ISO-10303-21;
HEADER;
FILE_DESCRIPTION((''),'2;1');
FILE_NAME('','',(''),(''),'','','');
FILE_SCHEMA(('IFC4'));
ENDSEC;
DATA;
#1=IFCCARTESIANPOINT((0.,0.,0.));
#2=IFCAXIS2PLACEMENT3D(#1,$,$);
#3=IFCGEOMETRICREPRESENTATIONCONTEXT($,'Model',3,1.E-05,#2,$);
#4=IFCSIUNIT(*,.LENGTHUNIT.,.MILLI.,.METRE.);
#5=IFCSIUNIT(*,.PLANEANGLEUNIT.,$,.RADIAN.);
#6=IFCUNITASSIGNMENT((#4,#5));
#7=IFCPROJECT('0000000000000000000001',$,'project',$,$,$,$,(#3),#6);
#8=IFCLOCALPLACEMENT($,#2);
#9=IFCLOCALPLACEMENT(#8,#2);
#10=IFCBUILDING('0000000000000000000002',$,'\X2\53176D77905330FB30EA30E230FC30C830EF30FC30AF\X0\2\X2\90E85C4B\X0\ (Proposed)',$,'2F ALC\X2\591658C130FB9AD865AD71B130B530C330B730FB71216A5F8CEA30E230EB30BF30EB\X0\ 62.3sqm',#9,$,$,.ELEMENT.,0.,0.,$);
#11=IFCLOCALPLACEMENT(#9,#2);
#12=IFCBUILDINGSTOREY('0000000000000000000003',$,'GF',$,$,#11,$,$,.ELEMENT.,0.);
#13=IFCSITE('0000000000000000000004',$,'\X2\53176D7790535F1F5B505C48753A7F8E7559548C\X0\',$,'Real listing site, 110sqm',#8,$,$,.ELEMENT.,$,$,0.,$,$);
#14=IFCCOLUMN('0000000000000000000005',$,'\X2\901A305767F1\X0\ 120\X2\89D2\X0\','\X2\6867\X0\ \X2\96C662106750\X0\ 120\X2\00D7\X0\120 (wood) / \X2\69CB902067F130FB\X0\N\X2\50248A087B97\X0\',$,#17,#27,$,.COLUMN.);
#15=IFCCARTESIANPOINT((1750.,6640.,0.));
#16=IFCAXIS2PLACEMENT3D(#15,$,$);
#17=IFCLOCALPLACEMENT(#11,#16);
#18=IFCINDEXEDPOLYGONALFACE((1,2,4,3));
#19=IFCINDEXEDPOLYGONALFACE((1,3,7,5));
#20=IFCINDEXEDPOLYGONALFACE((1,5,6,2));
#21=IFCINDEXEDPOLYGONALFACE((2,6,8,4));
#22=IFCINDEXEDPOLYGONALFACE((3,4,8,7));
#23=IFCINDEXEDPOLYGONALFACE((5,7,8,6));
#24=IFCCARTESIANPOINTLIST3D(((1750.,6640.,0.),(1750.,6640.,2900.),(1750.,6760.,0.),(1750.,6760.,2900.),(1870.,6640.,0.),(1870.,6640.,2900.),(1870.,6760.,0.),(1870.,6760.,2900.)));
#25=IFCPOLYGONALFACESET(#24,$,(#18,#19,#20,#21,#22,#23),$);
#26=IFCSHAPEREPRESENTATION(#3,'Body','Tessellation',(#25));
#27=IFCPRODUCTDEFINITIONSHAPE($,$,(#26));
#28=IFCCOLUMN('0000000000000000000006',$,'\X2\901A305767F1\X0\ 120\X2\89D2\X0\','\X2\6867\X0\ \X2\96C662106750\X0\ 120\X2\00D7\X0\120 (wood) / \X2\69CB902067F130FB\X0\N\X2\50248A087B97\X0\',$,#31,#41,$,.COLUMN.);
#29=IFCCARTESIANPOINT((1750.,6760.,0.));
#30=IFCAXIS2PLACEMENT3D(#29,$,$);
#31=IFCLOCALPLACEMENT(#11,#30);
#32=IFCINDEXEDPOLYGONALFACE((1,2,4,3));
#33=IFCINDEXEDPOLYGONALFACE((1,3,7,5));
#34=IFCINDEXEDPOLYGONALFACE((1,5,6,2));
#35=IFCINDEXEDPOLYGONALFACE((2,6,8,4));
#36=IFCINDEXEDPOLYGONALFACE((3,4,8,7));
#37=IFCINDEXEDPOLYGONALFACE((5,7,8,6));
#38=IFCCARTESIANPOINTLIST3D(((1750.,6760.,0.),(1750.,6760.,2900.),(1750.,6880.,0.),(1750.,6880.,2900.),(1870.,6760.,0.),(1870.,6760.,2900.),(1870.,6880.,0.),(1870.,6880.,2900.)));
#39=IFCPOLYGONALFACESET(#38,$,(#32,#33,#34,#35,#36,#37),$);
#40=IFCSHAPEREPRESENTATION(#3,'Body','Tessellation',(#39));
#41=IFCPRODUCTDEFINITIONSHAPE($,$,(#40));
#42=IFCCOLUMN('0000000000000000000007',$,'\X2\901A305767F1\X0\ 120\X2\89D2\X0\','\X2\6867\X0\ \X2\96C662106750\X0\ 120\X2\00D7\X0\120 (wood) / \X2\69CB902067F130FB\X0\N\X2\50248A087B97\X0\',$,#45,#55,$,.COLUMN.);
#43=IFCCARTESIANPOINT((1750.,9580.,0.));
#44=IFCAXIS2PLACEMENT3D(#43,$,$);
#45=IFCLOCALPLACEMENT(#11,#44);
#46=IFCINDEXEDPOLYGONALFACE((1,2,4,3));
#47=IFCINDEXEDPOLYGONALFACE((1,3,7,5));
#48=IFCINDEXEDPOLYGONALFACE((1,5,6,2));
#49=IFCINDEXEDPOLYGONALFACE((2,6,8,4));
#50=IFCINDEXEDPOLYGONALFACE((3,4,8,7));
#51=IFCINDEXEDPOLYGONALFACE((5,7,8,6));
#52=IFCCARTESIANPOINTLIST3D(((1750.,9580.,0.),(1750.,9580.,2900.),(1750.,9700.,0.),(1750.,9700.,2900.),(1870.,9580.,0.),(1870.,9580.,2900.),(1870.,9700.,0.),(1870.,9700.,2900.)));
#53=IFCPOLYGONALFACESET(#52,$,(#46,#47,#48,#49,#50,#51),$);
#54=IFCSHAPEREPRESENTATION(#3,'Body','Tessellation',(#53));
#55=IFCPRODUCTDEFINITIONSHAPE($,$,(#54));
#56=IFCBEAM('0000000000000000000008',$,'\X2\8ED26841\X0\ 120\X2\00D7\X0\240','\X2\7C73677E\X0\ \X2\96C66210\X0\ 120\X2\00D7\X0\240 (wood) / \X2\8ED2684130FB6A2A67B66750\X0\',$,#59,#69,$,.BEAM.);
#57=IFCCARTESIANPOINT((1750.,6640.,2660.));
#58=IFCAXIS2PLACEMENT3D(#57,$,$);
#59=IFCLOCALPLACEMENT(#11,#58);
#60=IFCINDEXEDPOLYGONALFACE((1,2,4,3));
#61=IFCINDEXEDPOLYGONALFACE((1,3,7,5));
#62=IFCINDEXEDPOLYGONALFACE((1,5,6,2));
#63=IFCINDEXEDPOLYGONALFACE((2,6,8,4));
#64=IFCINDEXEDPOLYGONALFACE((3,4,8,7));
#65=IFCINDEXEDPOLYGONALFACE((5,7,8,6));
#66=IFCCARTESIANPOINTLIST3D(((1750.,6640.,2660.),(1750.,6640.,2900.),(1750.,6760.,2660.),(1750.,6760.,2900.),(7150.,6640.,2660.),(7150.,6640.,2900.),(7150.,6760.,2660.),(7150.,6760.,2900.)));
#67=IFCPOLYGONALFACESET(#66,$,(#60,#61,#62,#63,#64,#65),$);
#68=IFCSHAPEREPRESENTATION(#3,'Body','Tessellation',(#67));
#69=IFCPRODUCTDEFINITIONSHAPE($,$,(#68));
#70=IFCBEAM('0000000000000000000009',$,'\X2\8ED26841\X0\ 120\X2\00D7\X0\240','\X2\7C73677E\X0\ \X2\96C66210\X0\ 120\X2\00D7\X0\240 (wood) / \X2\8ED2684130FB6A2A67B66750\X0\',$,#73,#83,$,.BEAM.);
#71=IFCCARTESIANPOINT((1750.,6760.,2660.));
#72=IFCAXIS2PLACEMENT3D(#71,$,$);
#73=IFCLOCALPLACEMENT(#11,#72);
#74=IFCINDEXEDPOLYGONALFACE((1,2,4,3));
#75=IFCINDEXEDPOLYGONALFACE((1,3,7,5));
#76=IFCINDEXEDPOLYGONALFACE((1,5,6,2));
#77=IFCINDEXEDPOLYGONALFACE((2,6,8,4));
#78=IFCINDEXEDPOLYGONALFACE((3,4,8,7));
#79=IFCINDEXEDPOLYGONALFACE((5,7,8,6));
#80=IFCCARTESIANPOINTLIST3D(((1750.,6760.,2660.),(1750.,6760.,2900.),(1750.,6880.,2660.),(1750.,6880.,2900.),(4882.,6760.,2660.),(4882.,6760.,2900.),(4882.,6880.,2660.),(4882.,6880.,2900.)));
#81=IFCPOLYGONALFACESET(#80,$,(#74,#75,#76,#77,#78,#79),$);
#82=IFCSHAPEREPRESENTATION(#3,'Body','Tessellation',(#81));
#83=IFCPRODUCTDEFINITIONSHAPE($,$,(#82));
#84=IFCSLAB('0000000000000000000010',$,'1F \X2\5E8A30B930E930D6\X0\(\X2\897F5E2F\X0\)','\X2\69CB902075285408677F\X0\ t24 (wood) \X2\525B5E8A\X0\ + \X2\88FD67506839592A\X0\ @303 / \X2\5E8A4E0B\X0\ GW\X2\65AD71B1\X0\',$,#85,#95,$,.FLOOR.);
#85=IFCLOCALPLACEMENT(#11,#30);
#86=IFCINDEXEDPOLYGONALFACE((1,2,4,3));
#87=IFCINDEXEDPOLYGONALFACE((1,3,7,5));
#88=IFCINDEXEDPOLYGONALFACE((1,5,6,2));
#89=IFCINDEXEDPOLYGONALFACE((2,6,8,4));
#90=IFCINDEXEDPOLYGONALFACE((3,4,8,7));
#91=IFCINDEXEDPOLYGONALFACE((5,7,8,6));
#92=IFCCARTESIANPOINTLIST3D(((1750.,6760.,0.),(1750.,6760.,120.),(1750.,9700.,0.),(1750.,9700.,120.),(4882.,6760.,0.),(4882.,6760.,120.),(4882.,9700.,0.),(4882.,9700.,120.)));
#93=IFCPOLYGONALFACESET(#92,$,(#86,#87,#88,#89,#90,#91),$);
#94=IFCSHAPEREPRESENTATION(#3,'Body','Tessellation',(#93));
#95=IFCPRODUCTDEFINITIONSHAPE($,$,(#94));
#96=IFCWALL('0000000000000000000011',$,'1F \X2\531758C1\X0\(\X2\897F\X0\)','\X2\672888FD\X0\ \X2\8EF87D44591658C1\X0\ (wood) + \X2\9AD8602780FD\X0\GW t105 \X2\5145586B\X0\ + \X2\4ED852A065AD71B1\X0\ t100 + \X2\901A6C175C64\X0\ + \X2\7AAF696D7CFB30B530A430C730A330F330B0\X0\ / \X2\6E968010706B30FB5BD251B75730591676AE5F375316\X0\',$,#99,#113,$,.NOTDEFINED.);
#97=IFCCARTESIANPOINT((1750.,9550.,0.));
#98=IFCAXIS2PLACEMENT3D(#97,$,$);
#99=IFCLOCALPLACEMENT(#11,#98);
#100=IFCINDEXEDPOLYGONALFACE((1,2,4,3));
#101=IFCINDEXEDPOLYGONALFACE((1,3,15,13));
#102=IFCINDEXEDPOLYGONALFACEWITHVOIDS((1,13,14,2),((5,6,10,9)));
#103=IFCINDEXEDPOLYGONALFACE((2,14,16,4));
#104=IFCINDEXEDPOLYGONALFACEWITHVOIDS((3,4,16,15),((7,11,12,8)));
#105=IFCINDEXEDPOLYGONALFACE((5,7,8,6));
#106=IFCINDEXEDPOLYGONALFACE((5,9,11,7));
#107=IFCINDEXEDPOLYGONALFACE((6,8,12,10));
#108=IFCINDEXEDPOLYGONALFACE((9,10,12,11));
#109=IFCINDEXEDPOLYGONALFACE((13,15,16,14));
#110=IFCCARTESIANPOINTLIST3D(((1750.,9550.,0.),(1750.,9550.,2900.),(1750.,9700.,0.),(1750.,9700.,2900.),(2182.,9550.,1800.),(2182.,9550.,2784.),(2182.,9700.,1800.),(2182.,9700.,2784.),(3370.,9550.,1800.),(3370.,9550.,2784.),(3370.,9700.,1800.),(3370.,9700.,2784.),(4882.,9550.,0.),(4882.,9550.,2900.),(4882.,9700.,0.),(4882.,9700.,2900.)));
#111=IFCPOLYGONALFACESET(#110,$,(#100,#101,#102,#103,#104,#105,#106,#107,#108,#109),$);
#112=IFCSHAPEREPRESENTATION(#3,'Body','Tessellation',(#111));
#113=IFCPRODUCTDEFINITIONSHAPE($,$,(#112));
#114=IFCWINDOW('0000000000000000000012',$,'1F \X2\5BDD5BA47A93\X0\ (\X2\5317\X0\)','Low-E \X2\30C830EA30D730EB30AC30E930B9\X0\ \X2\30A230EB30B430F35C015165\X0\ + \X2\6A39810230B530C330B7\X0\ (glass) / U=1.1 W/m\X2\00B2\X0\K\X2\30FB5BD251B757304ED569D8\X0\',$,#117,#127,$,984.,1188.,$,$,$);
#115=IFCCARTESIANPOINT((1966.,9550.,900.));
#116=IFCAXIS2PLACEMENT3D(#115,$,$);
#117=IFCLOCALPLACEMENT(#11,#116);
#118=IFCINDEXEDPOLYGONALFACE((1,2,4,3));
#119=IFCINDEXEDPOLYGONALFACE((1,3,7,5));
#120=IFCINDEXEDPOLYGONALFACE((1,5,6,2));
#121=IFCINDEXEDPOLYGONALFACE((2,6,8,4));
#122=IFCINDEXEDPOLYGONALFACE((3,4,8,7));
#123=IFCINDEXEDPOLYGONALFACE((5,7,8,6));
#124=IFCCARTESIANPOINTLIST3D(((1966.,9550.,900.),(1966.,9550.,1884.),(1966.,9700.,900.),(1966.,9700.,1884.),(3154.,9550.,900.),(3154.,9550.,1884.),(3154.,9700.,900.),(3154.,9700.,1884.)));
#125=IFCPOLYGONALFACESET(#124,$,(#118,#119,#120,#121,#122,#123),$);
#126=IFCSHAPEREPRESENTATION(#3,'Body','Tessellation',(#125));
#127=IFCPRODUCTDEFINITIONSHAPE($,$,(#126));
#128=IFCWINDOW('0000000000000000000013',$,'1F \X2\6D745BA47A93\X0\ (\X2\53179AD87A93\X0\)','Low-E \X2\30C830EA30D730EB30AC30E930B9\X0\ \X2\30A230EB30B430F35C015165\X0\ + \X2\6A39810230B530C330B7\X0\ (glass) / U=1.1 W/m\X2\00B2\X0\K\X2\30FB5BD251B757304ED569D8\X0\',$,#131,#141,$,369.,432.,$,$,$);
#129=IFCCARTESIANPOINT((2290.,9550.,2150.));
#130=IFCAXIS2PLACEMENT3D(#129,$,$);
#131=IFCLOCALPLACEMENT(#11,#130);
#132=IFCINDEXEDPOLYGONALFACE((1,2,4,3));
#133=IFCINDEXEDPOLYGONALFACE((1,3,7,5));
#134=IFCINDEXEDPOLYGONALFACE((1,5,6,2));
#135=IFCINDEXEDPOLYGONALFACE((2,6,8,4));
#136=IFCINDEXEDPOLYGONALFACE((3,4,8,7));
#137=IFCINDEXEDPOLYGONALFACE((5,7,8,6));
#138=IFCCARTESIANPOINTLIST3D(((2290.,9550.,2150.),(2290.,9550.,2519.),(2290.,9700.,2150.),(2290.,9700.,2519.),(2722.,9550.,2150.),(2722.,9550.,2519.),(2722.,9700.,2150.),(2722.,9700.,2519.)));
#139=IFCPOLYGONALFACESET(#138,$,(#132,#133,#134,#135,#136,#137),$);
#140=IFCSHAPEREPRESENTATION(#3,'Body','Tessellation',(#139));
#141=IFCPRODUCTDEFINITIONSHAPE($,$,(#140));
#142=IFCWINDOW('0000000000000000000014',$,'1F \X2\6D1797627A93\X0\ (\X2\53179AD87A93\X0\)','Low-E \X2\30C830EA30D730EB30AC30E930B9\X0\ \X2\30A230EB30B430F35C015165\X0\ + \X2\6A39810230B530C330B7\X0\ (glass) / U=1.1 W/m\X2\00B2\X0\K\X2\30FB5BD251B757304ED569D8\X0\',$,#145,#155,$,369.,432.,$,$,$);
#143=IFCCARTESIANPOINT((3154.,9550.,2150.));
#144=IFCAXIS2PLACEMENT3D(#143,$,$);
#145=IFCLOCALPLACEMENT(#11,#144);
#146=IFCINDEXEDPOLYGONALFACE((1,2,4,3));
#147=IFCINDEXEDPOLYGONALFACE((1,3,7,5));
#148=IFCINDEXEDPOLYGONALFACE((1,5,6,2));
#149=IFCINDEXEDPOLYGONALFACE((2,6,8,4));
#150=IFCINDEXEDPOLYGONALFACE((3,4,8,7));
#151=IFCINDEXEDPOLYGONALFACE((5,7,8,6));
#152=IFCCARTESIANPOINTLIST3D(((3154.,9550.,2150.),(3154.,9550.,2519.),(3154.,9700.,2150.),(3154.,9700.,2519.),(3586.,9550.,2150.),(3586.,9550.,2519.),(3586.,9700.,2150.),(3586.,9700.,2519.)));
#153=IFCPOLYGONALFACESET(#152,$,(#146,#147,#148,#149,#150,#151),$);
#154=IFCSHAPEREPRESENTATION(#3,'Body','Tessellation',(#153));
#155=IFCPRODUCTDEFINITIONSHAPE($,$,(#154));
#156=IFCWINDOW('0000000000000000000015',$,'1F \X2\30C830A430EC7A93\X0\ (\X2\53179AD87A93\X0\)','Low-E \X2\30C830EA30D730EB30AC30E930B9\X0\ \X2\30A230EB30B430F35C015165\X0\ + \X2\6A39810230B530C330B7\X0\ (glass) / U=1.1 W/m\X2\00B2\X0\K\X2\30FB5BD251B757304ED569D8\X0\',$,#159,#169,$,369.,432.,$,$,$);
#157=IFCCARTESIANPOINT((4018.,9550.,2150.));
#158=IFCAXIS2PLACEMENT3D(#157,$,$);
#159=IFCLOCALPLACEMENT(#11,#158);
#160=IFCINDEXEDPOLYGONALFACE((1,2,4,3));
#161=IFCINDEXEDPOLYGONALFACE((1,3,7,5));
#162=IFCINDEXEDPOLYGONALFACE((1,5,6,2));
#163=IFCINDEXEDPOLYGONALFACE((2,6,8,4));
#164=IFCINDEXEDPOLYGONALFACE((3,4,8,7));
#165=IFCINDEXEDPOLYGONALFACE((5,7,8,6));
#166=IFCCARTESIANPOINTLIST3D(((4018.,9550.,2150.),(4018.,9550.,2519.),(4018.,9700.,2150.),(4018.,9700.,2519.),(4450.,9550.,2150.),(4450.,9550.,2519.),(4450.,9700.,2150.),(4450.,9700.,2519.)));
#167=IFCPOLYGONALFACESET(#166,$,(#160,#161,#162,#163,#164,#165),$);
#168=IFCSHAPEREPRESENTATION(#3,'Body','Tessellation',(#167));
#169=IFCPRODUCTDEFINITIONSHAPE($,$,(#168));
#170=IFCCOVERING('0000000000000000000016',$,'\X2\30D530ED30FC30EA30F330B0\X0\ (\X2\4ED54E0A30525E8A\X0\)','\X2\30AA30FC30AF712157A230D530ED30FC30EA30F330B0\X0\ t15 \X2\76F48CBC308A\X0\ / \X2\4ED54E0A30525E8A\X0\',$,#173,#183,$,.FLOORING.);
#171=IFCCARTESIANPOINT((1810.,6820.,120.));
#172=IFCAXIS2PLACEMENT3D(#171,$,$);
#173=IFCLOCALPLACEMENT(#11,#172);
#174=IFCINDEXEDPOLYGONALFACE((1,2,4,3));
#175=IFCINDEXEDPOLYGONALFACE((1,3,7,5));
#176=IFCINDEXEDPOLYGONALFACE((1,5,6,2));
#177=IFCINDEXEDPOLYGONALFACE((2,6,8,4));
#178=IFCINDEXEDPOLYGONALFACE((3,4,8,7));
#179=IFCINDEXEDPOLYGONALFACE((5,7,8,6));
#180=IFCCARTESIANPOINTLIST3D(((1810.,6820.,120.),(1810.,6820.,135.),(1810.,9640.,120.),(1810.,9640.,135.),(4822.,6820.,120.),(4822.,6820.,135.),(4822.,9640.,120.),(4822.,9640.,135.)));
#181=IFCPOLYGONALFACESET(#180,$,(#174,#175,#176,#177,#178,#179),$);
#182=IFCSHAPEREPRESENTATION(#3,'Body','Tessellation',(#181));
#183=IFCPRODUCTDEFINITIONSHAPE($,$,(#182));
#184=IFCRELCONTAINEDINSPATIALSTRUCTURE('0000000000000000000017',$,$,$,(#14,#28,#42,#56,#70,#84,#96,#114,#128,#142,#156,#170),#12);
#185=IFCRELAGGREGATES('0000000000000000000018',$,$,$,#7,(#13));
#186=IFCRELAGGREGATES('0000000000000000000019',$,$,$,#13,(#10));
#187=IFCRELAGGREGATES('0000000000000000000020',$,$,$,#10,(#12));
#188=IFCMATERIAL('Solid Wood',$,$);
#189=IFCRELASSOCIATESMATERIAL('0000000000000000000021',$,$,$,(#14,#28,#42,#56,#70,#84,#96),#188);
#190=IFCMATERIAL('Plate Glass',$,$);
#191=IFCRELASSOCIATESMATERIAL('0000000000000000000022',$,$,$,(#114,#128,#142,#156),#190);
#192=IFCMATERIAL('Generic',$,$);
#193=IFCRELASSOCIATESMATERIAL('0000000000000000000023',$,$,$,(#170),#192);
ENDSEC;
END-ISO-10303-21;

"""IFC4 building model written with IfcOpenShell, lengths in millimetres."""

from ifc_helpers import new_model, si_unit, frame, frame_2d, origin, place, context, project, spatial, rectangle, extrude, material, element, fill, save


model = new_model("IFC4")

# Units and contexts
model_context = context("Model", 3, precision=1e-05, world=origin())
ifc_project = project(units=[si_unit("LENGTHUNIT", "METRE", prefix="MILLI"), si_unit("PLANEANGLEUNIT", "RADIAN")], contexts=[model_context])

# Site, building, storey
site_placement = place(None, origin())
site = spatial("IfcSite", under=ifc_project, at=site_placement, Name="北海道弟子屈町美留和", ObjectType="Real listing site, 110sqm", CompositionType="ELEMENT", RefElevation=0.0)
building_placement = place(site_placement, origin())
building = spatial("IfcBuilding", under=site, at=building_placement, Name="北海道・リモートワーク2部屋 (Proposed)", ObjectType="2F ALC外壁・高断熱サッシ・無機質モルタル 62.3sqm", CompositionType="ELEMENT", ElevationOfRefHeight=0.0, ElevationOfTerrain=0.0)
storey_placement = place(building_placement, origin())
storey = spatial("IfcBuildingStorey", under=building, at=storey_placement, Name="GF", CompositionType="ELEMENT", Elevation=0.0)

# Columns
ifc_material_1 = material(Name="Solid Wood")
column_1_placement = place(storey_placement, frame((1750.0, 6640.0, 0.0)))
element("IfcColumn", 1, at=column_1_placement, inside=storey, material=ifc_material_1, Name="通し柱 120角", Description="桧 集成材 120×120 (wood) / 構造柱・N値計算", PredefinedType="COLUMN", context=model_context, shape_type="SweptSolid", body=[
    extrude(rectangle(XDim=120.0, YDim=120.0, at=frame_2d((60.0, 60.0))), frame((1750.0, 6640.0, 0.0)), (0.0, 0.0, 1.0), 2900.0),
])
column_2_placement = place(storey_placement, frame((1750.0, 6760.0, 0.0)))
element("IfcColumn", 2, at=column_2_placement, inside=storey, material=ifc_material_1, Name="通し柱 120角", Description="桧 集成材 120×120 (wood) / 構造柱・N値計算", PredefinedType="COLUMN", context=model_context, shape_type="SweptSolid", body=[
    extrude(rectangle(XDim=120.0, YDim=120.0, at=frame_2d((60.0, 60.0))), frame((1750.0, 6760.0, 0.0)), (0.0, 0.0, 1.0), 2900.0),
])
column_3_placement = place(storey_placement, frame((1750.0, 9580.0, 0.0)))
element("IfcColumn", 3, at=column_3_placement, inside=storey, material=ifc_material_1, Name="通し柱 120角", Description="桧 集成材 120×120 (wood) / 構造柱・N値計算", PredefinedType="COLUMN", context=model_context, shape_type="SweptSolid", body=[
    extrude(rectangle(XDim=120.0, YDim=120.0, at=frame_2d((60.0, 60.0))), frame((1750.0, 9580.0, 0.0)), (0.0, 0.0, 1.0), 2900.0),
])

# Beams
beam_1_placement = place(storey_placement, frame((1750.0, 6640.0, 2660.0)))
element("IfcBeam", 4, at=beam_1_placement, inside=storey, material=ifc_material_1, Name="軒桁 120×240", Description="米松 集成 120×240 (wood) / 軒桁・横架材", PredefinedType="BEAM", context=model_context, shape_type="SweptSolid", body=[
    extrude(rectangle(XDim=5400.0, YDim=120.0, at=frame_2d((2700.0, 60.0))), frame((1750.0, 6640.0, 2660.0)), (0.0, 0.0, 1.0), 240.0),
])
beam_2_placement = place(storey_placement, frame((1750.0, 6760.0, 2660.0)))
element("IfcBeam", 5, at=beam_2_placement, inside=storey, material=ifc_material_1, Name="軒桁 120×240", Description="米松 集成 120×240 (wood) / 軒桁・横架材", PredefinedType="BEAM", context=model_context, shape_type="SweptSolid", body=[
    extrude(rectangle(XDim=3132.0, YDim=120.0, at=frame_2d((1566.0, 60.0))), frame((1750.0, 6760.0, 2660.0)), (0.0, 0.0, 1.0), 240.0),
])

# Slab
slab_placement = place(storey_placement, frame((1750.0, 6760.0, 0.0)))
element("IfcSlab", 6, at=slab_placement, inside=storey, material=ifc_material_1, Name="1F 床スラブ(西帯)", Description="構造用合板 t24 (wood) 剛床 + 製材根太 @303 / 床下 GW断熱", PredefinedType="FLOOR", context=model_context, shape_type="SweptSolid", body=[
    extrude(rectangle(XDim=3132.0, YDim=2940.0, at=frame_2d((1566.0, 1470.0))), frame((1750.0, 6760.0, 0.0)), (0.0, 0.0, 1.0), 120.0),
])

# Wall, openings, windows
wall_1_placement = place(storey_placement, frame((1750.0, 9550.0, 0.0)))
wall_1 = element("IfcWall", 7, at=wall_1_placement, inside=storey, material=ifc_material_1, Name="1F 北壁(西)", Description="木製 軸組外壁 (wood) + 高性能GW t105 充填 + 付加断熱 t100 + 通気層 + 窯業系サイディング / 準耐火・寒冷地外皮強化", PredefinedType="NOTDEFINED", context=model_context, shape_type="SweptSolid", body=[
    extrude(rectangle(XDim=3132.0, YDim=150.0, at=frame_2d((1566.0, 75.0))), frame((1750.0, 9550.0, 0.0)), (0.0, 0.0, 1.0), 2900.0),
])
opening_1_placement = place(storey_placement, frame((1966.0, 9550.0, 900.0)))
opening_1 = element("IfcOpeningElement", 8, at=opening_1_placement, cuts=wall_1, PredefinedType="NOTDEFINED", context=model_context, shape_type="SweptSolid", body=[
    extrude(rectangle(XDim=1188.0, YDim=150.0, at=frame_2d((594.0, 75.0))), frame((1966.0, 9550.0, 900.0)), (0.0, 0.0, 1.0), 984.0),
])
opening_2_placement = place(storey_placement, frame((2290.0, 9550.0, 2150.0)))
opening_2 = element("IfcOpeningElement", 9, at=opening_2_placement, cuts=wall_1, PredefinedType="NOTDEFINED", context=model_context, shape_type="SweptSolid", body=[
    extrude(rectangle(XDim=432.0, YDim=150.0, at=frame_2d((216.0, 75.0))), frame((2290.0, 9550.0, 2150.0)), (0.0, 0.0, 1.0), 369.0),
])
opening_3_placement = place(storey_placement, frame((3154.0, 9550.0, 2150.0)))
opening_3 = element("IfcOpeningElement", 10, at=opening_3_placement, cuts=wall_1, PredefinedType="NOTDEFINED", context=model_context, shape_type="SweptSolid", body=[
    extrude(rectangle(XDim=432.0, YDim=150.0, at=frame_2d((216.0, 75.0))), frame((3154.0, 9550.0, 2150.0)), (0.0, 0.0, 1.0), 369.0),
])
opening_4_placement = place(storey_placement, frame((4018.0, 9550.0, 2150.0)))
opening_4 = element("IfcOpeningElement", 11, at=opening_4_placement, cuts=wall_1, PredefinedType="NOTDEFINED", context=model_context, shape_type="SweptSolid", body=[
    extrude(rectangle(XDim=432.0, YDim=150.0, at=frame_2d((216.0, 75.0))), frame((4018.0, 9550.0, 2150.0)), (0.0, 0.0, 1.0), 369.0),
])
ifc_material_2 = material(Name="Plate Glass")
window_1_placement = place(storey_placement, frame((1966.0, 9550.0, 900.0)))
window_1 = element("IfcWindow", 12, at=window_1_placement, inside=storey, material=ifc_material_2, Name="1F 寝室窓 (北)", Description="Low-E トリプルガラス アルゴン封入 + 樹脂サッシ (glass) / U=1.1 W/m²K・寒冷地仕様", OverallHeight=984.0, OverallWidth=1188.0, context=model_context, shape_type="SweptSolid", body=[
    extrude(rectangle(XDim=1188.0, YDim=150.0, at=frame_2d((594.0, 75.0))), frame((1966.0, 9550.0, 900.0)), (0.0, 0.0, 1.0), 984.0),
])
fill(opening_1, window_1)
window_2_placement = place(storey_placement, frame((2290.0, 9550.0, 2150.0)))
window_2 = element("IfcWindow", 13, at=window_2_placement, inside=storey, material=ifc_material_2, Name="1F 浴室窓 (北高窓)", Description="Low-E トリプルガラス アルゴン封入 + 樹脂サッシ (glass) / U=1.1 W/m²K・寒冷地仕様", OverallHeight=369.0, OverallWidth=432.0, context=model_context, shape_type="SweptSolid", body=[
    extrude(rectangle(XDim=432.0, YDim=150.0, at=frame_2d((216.0, 75.0))), frame((2290.0, 9550.0, 2150.0)), (0.0, 0.0, 1.0), 369.0),
])
fill(opening_2, window_2)
window_3_placement = place(storey_placement, frame((3154.0, 9550.0, 2150.0)))
window_3 = element("IfcWindow", 14, at=window_3_placement, inside=storey, material=ifc_material_2, Name="1F 洗面窓 (北高窓)", Description="Low-E トリプルガラス アルゴン封入 + 樹脂サッシ (glass) / U=1.1 W/m²K・寒冷地仕様", OverallHeight=369.0, OverallWidth=432.0, context=model_context, shape_type="SweptSolid", body=[
    extrude(rectangle(XDim=432.0, YDim=150.0, at=frame_2d((216.0, 75.0))), frame((3154.0, 9550.0, 2150.0)), (0.0, 0.0, 1.0), 369.0),
])
fill(opening_3, window_3)
window_4_placement = place(storey_placement, frame((4018.0, 9550.0, 2150.0)))
window_4 = element("IfcWindow", 15, at=window_4_placement, inside=storey, material=ifc_material_2, Name="1F トイレ窓 (北高窓)", Description="Low-E トリプルガラス アルゴン封入 + 樹脂サッシ (glass) / U=1.1 W/m²K・寒冷地仕様", OverallHeight=369.0, OverallWidth=432.0, context=model_context, shape_type="SweptSolid", body=[
    extrude(rectangle(XDim=432.0, YDim=150.0, at=frame_2d((216.0, 75.0))), frame((4018.0, 9550.0, 2150.0)), (0.0, 0.0, 1.0), 369.0),
])
fill(opening_4, window_4)

# Covering
ifc_material_3 = material(Name="Generic")
covering_placement = place(storey_placement, frame((1810.0, 6820.0, 120.0)))
element("IfcCovering", 16, at=covering_placement, inside=storey, material=ifc_material_3, Name="フローリング (仕上げ床)", Description="オーク無垢フローリング t15 直貼り / 仕上げ床", PredefinedType="FLOORING", context=model_context, shape_type="SweptSolid", body=[
    extrude(rectangle(XDim=3012.0, YDim=2820.0, at=frame_2d((1506.0, 1410.0))), frame((1810.0, 6820.0, 120.0)), (0.0, 0.0, 1.0), 15.0),
])

save(model, "model.ifc")
